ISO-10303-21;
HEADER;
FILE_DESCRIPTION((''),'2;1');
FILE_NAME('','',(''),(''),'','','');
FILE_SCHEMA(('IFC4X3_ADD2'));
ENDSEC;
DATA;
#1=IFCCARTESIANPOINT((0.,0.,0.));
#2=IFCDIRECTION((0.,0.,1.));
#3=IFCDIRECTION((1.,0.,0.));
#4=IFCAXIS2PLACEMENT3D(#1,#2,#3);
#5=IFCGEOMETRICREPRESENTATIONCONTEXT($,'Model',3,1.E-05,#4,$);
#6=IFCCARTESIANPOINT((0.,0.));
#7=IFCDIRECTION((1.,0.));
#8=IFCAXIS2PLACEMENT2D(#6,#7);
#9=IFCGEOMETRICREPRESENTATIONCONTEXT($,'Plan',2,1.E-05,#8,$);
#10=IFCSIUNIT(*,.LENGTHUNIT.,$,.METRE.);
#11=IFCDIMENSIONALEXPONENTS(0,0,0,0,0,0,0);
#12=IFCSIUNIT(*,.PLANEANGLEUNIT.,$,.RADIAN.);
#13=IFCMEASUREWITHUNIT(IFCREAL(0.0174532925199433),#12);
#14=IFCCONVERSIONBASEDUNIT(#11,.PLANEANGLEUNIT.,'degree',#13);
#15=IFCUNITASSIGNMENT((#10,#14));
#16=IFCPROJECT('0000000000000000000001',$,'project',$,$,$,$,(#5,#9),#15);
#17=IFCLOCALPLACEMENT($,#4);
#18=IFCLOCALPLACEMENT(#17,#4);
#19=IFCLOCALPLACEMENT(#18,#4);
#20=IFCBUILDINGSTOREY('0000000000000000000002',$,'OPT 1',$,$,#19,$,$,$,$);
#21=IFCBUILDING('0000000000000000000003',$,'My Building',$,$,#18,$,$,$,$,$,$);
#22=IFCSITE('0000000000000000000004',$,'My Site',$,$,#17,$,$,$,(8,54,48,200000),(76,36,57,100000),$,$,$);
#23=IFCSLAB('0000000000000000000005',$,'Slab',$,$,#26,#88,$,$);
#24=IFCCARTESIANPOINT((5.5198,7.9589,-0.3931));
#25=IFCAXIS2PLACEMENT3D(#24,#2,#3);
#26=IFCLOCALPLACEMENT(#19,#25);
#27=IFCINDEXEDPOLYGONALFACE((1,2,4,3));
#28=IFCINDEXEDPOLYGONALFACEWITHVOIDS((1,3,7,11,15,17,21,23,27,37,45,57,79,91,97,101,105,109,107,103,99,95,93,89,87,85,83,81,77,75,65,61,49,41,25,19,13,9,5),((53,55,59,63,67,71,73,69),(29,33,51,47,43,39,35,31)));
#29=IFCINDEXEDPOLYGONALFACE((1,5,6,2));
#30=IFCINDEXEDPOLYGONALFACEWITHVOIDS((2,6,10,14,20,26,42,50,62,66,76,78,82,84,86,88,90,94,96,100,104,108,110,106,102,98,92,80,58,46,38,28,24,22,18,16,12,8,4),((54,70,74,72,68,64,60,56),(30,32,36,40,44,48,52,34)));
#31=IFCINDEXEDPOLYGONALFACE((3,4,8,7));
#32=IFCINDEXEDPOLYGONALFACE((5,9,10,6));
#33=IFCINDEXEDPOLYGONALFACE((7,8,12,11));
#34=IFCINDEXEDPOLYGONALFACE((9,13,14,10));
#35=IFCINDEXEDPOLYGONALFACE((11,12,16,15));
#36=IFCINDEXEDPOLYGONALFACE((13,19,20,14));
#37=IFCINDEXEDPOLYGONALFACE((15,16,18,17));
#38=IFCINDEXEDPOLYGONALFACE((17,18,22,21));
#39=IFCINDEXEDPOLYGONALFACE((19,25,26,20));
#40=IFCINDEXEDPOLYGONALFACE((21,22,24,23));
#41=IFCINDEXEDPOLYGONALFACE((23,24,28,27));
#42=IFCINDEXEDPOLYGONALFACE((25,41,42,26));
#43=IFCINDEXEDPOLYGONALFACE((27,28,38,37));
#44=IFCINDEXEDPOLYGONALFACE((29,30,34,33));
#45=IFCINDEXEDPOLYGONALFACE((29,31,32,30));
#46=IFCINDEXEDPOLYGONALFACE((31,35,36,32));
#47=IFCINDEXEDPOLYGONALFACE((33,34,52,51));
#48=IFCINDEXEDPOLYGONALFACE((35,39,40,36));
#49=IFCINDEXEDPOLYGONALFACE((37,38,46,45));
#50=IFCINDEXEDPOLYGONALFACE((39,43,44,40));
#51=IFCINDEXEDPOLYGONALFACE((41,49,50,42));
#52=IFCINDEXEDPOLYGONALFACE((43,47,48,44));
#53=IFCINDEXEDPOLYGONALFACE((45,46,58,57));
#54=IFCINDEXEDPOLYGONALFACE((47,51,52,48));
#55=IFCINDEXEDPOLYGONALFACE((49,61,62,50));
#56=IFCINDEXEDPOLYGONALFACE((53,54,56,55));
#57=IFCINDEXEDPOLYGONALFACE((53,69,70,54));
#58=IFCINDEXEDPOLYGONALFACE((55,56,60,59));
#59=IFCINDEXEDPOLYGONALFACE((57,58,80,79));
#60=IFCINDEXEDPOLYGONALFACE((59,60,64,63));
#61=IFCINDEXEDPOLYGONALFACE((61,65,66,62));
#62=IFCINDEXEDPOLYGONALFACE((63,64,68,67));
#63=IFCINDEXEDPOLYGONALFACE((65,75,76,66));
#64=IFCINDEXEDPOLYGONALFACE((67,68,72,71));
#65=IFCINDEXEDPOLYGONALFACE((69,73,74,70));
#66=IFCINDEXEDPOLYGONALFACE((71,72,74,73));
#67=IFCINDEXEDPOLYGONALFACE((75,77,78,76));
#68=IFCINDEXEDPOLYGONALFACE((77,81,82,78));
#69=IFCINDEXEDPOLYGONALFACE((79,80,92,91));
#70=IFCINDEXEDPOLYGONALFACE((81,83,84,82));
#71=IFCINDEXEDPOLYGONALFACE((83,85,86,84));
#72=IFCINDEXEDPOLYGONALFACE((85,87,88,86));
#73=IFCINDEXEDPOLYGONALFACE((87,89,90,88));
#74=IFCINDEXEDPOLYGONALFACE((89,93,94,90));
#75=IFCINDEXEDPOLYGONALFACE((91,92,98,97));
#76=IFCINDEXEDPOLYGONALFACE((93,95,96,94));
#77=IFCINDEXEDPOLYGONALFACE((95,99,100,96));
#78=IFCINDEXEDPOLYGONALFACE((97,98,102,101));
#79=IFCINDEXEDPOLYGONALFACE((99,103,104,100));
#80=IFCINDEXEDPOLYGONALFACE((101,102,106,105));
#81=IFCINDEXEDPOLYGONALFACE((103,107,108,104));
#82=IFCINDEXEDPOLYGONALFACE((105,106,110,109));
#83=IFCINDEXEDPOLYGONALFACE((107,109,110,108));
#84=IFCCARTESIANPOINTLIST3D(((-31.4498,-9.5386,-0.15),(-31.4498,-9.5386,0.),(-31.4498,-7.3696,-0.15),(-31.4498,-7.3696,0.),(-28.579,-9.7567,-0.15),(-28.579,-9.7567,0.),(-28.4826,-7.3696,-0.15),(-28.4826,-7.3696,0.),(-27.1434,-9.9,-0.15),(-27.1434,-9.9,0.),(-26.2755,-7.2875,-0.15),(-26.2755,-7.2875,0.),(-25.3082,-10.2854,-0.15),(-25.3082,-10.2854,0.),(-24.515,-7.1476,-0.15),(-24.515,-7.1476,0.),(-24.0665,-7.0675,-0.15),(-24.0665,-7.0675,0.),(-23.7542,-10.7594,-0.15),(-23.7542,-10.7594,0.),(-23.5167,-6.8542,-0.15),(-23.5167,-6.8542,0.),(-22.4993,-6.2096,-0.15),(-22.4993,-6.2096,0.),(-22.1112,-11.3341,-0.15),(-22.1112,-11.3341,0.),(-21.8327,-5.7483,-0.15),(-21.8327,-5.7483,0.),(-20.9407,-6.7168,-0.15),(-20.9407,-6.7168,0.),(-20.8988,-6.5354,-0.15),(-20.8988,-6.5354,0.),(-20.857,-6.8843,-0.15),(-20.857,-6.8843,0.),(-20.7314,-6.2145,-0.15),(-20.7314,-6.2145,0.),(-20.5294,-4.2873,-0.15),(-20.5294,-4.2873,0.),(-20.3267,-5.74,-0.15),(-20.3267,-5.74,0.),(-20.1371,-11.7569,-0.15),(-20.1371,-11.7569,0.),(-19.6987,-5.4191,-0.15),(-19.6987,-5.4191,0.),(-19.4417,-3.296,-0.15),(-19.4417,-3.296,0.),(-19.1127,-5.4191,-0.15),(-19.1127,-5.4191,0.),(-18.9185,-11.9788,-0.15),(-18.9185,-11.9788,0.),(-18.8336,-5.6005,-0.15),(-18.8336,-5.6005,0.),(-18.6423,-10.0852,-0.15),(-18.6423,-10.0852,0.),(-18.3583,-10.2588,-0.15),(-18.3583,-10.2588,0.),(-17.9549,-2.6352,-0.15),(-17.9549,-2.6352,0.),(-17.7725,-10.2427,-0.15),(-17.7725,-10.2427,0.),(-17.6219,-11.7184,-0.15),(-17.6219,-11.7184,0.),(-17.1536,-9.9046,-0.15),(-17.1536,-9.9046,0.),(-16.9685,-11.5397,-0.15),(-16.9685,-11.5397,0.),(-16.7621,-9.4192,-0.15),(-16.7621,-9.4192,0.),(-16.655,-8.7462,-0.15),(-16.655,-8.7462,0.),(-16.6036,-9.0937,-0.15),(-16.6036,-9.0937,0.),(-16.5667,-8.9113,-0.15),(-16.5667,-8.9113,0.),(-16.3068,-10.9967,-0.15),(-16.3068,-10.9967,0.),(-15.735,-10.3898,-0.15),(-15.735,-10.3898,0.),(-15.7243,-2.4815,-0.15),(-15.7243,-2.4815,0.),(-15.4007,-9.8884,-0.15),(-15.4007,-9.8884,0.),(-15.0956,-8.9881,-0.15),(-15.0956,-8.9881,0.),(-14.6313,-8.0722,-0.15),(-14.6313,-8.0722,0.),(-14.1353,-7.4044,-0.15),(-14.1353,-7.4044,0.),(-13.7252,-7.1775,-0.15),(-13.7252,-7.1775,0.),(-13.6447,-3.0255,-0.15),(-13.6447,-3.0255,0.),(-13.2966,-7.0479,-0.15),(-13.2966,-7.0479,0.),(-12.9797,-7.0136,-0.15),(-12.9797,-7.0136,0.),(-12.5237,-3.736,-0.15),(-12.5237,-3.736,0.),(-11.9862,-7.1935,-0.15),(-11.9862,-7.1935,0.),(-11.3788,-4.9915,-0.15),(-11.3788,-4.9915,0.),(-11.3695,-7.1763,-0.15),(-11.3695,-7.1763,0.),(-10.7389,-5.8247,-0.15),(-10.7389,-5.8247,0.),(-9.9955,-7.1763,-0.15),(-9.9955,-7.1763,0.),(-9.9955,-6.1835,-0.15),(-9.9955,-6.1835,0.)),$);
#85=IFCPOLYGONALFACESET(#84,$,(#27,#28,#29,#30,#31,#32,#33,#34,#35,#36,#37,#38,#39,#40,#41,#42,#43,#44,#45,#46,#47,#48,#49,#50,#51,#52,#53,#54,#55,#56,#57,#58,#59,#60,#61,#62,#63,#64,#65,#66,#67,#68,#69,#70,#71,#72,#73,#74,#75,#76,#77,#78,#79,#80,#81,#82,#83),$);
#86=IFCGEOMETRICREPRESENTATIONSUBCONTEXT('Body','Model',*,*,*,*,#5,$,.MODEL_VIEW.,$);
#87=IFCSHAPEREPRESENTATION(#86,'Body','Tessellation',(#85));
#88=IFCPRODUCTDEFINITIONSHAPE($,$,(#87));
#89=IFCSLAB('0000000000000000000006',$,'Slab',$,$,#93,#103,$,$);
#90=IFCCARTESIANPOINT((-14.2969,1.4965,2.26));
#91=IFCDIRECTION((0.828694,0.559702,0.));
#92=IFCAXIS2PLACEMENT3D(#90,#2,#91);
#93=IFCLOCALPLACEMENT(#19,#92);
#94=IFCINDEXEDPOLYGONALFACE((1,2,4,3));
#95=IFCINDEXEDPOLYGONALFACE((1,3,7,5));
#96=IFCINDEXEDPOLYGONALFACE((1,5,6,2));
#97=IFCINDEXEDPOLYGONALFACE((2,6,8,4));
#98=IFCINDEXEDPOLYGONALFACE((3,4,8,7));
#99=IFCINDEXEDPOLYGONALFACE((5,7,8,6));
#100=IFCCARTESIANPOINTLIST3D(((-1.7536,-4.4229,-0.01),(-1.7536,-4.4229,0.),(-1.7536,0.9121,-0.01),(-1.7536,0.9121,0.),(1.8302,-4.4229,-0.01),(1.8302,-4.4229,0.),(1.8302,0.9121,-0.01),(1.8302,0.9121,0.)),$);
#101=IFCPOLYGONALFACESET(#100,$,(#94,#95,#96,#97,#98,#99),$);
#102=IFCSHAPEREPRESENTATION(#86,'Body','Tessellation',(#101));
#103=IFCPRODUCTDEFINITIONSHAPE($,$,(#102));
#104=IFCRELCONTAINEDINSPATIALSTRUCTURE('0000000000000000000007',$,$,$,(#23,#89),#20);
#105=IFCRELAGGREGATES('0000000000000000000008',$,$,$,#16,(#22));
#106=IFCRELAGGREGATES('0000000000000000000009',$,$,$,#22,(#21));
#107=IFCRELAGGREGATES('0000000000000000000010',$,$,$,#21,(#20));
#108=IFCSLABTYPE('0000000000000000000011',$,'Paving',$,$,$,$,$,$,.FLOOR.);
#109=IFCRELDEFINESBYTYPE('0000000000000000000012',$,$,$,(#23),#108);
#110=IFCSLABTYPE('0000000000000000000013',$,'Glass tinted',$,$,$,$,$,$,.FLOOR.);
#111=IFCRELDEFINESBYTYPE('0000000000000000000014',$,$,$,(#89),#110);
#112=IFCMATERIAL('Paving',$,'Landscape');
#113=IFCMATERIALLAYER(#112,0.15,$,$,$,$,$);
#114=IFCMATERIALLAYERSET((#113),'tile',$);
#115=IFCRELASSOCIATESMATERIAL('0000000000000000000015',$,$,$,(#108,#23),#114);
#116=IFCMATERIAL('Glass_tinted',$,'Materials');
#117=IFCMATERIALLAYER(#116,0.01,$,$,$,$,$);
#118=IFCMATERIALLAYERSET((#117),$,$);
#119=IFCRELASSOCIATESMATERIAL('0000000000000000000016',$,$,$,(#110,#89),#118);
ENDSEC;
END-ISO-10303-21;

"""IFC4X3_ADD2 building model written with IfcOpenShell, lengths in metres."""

from ifc_helpers import new_model, entity, si_unit, converted_unit, frame, origin_with_axes, origin_2d_with_axis, place, context, subcontext, project, spatial, indexed_curve, outline, extrude, material, layer, layer_set, layer_usage, type_object, element, save


model = new_model("IFC4X3_ADD2")

# Units and contexts
model_context = context("Model", 3, precision=1e-05, world=origin_with_axes())
plan_context = context("Plan", 2, precision=1e-05, world=origin_2d_with_axis())
body_context = subcontext(model_context, "Body", "Model", "MODEL_VIEW")
ifc_project = project(units=[si_unit("LENGTHUNIT", "METRE"), converted_unit("PLANEANGLEUNIT", "degree", entity("IfcReal", 0.0174532925199433), si_unit("PLANEANGLEUNIT", "RADIAN"), dimensions=[0, 0, 0, 0, 0, 0, 0])], contexts=[model_context, plan_context])

# Site, building, storey
site_placement = place(None, origin_with_axes())
site = spatial("IfcSite", under=ifc_project, at=site_placement, Name="My Site", RefLatitude=(8, 54, 48, 200000), RefLongitude=(76, 36, 57, 100000))
building_placement = place(site_placement, origin_with_axes())
building = spatial("IfcBuilding", under=site, at=building_placement, Name="My Building")
storey_placement = place(building_placement, origin_with_axes())
storey = spatial("IfcBuildingStorey", under=building, at=storey_placement, Name="OPT 1")

# Slabs
ifc_material_1 = material(Name="Paving", Category="Landscape")
ifc_layer_1 = layer(ifc_material_1, 0.15)
ifc_layer_set_1 = layer_set([ifc_layer_1], Name="tile")
ifc_layer_usage_1 = layer_usage(ifc_layer_set_1, "AXIS3", "POSITIVE", -0.15)
slab_type_1 = type_object("IfcSlabType", Name="Paving", PredefinedType="FLOOR", material=ifc_layer_set_1)
slab_1_placement = place(storey_placement, frame((5.5198, 7.9589, -0.3931), z_axis=(0.0, 0.0, 1.0), x_axis=(1.0, 0.0, 0.0)))
element("IfcSlab", 1, at=slab_1_placement, inside=storey, type_object=slab_type_1, material=ifc_layer_usage_1, Name="Slab", context=body_context, shape_type="SweptSolid", body=[
    extrude(outline(indexed_curve([(-23.7542, -10.7594), (-22.1112, -11.3341), (-20.1371, -11.7569), (-18.9185, -11.9788), (-17.6219, -11.7184), (-16.9685, -11.5397), (-16.3068, -10.9967), (-15.735, -10.3898), (-15.4007, -9.8884), (-15.0956, -8.9881), (-14.6313, -8.0722), (-14.1353, -7.4044), (-13.7252, -7.1775), (-13.2966, -7.0479), (-12.9797, -7.0136), (-11.9862, -7.1935), (-11.3695, -7.1763), (-9.9955, -7.1763), (-9.9955, -6.1835), (-10.7389, -5.8247), (-11.3788, -4.9915), (-12.5237, -3.736), (-13.6447, -3.0255), (-15.7243, -2.4815), (-17.9549, -2.6352), (-19.4417, -3.296), (-20.5294, -4.2873), (-21.8327, -5.7483), (-22.4993, -6.2096), (-23.5167, -6.8542), (-24.0665, -7.0675), (-24.515, -7.1476), (-26.2755, -7.2875), (-28.4826, -7.3696), (-31.4498, -7.3696), (-31.4498, -9.5386), (-28.579, -9.7567), (-27.1434, -9.9), (-25.3082, -10.2854), (-23.7542, -10.7594)]), holes=[indexed_curve([(-20.857, -6.8843), (-18.8336, -5.6005), (-19.1127, -5.4191), (-19.6987, -5.4191), (-20.3267, -5.74), (-20.7314, -6.2145), (-20.8988, -6.5354), (-20.9407, -6.7168), (-20.857, -6.8843)]), indexed_curve([(-16.655, -8.7462), (-18.6423, -10.0852), (-18.3583, -10.2588), (-17.7725, -10.2427), (-17.1536, -9.9046), (-16.7621, -9.4192), (-16.6036, -9.0937), (-16.5667, -8.9113), (-16.655, -8.7462)])]), frame((0.0, 0.0, -0.15), z_axis=(0.0, 0.0, 1.0), x_axis=(1.0, 0.0, 0.0)), (0.0, 0.0, 1.0), 0.15),
])
ifc_material_2 = material(Name="Glass_tinted", Category="Materials")
ifc_layer_2 = layer(ifc_material_2, 0.01)
ifc_layer_set_2 = layer_set([ifc_layer_2])
ifc_layer_usage_2 = layer_usage(ifc_layer_set_2, "AXIS3", "POSITIVE", -0.01)
slab_type_2 = type_object("IfcSlabType", Name="Glass tinted", PredefinedType="FLOOR", material=ifc_layer_set_2)
slab_2_placement = place(storey_placement, frame((-14.2969, 1.4965, 2.26), z_axis=(0.0, 0.0, 1.0), x_axis=(0.828694, 0.559702, 0.0)))
element("IfcSlab", 2, at=slab_2_placement, inside=storey, type_object=slab_type_2, material=ifc_layer_usage_2, Name="Slab", context=body_context, shape_type="SweptSolid", body=[
    extrude(outline(indexed_curve([(-1.7536, -4.4229), (1.8302, -4.4229), (1.8302, 0.9121), (-1.7536, 0.9121), (-1.7536, -4.4229)])), frame((0.0, 0.0, -0.01), z_axis=(0.0, 0.0, 1.0), x_axis=(1.0, 0.0, 0.0)), (0.0, 0.0, 1.0), 0.01),
])

save(model, "model.ifc")
